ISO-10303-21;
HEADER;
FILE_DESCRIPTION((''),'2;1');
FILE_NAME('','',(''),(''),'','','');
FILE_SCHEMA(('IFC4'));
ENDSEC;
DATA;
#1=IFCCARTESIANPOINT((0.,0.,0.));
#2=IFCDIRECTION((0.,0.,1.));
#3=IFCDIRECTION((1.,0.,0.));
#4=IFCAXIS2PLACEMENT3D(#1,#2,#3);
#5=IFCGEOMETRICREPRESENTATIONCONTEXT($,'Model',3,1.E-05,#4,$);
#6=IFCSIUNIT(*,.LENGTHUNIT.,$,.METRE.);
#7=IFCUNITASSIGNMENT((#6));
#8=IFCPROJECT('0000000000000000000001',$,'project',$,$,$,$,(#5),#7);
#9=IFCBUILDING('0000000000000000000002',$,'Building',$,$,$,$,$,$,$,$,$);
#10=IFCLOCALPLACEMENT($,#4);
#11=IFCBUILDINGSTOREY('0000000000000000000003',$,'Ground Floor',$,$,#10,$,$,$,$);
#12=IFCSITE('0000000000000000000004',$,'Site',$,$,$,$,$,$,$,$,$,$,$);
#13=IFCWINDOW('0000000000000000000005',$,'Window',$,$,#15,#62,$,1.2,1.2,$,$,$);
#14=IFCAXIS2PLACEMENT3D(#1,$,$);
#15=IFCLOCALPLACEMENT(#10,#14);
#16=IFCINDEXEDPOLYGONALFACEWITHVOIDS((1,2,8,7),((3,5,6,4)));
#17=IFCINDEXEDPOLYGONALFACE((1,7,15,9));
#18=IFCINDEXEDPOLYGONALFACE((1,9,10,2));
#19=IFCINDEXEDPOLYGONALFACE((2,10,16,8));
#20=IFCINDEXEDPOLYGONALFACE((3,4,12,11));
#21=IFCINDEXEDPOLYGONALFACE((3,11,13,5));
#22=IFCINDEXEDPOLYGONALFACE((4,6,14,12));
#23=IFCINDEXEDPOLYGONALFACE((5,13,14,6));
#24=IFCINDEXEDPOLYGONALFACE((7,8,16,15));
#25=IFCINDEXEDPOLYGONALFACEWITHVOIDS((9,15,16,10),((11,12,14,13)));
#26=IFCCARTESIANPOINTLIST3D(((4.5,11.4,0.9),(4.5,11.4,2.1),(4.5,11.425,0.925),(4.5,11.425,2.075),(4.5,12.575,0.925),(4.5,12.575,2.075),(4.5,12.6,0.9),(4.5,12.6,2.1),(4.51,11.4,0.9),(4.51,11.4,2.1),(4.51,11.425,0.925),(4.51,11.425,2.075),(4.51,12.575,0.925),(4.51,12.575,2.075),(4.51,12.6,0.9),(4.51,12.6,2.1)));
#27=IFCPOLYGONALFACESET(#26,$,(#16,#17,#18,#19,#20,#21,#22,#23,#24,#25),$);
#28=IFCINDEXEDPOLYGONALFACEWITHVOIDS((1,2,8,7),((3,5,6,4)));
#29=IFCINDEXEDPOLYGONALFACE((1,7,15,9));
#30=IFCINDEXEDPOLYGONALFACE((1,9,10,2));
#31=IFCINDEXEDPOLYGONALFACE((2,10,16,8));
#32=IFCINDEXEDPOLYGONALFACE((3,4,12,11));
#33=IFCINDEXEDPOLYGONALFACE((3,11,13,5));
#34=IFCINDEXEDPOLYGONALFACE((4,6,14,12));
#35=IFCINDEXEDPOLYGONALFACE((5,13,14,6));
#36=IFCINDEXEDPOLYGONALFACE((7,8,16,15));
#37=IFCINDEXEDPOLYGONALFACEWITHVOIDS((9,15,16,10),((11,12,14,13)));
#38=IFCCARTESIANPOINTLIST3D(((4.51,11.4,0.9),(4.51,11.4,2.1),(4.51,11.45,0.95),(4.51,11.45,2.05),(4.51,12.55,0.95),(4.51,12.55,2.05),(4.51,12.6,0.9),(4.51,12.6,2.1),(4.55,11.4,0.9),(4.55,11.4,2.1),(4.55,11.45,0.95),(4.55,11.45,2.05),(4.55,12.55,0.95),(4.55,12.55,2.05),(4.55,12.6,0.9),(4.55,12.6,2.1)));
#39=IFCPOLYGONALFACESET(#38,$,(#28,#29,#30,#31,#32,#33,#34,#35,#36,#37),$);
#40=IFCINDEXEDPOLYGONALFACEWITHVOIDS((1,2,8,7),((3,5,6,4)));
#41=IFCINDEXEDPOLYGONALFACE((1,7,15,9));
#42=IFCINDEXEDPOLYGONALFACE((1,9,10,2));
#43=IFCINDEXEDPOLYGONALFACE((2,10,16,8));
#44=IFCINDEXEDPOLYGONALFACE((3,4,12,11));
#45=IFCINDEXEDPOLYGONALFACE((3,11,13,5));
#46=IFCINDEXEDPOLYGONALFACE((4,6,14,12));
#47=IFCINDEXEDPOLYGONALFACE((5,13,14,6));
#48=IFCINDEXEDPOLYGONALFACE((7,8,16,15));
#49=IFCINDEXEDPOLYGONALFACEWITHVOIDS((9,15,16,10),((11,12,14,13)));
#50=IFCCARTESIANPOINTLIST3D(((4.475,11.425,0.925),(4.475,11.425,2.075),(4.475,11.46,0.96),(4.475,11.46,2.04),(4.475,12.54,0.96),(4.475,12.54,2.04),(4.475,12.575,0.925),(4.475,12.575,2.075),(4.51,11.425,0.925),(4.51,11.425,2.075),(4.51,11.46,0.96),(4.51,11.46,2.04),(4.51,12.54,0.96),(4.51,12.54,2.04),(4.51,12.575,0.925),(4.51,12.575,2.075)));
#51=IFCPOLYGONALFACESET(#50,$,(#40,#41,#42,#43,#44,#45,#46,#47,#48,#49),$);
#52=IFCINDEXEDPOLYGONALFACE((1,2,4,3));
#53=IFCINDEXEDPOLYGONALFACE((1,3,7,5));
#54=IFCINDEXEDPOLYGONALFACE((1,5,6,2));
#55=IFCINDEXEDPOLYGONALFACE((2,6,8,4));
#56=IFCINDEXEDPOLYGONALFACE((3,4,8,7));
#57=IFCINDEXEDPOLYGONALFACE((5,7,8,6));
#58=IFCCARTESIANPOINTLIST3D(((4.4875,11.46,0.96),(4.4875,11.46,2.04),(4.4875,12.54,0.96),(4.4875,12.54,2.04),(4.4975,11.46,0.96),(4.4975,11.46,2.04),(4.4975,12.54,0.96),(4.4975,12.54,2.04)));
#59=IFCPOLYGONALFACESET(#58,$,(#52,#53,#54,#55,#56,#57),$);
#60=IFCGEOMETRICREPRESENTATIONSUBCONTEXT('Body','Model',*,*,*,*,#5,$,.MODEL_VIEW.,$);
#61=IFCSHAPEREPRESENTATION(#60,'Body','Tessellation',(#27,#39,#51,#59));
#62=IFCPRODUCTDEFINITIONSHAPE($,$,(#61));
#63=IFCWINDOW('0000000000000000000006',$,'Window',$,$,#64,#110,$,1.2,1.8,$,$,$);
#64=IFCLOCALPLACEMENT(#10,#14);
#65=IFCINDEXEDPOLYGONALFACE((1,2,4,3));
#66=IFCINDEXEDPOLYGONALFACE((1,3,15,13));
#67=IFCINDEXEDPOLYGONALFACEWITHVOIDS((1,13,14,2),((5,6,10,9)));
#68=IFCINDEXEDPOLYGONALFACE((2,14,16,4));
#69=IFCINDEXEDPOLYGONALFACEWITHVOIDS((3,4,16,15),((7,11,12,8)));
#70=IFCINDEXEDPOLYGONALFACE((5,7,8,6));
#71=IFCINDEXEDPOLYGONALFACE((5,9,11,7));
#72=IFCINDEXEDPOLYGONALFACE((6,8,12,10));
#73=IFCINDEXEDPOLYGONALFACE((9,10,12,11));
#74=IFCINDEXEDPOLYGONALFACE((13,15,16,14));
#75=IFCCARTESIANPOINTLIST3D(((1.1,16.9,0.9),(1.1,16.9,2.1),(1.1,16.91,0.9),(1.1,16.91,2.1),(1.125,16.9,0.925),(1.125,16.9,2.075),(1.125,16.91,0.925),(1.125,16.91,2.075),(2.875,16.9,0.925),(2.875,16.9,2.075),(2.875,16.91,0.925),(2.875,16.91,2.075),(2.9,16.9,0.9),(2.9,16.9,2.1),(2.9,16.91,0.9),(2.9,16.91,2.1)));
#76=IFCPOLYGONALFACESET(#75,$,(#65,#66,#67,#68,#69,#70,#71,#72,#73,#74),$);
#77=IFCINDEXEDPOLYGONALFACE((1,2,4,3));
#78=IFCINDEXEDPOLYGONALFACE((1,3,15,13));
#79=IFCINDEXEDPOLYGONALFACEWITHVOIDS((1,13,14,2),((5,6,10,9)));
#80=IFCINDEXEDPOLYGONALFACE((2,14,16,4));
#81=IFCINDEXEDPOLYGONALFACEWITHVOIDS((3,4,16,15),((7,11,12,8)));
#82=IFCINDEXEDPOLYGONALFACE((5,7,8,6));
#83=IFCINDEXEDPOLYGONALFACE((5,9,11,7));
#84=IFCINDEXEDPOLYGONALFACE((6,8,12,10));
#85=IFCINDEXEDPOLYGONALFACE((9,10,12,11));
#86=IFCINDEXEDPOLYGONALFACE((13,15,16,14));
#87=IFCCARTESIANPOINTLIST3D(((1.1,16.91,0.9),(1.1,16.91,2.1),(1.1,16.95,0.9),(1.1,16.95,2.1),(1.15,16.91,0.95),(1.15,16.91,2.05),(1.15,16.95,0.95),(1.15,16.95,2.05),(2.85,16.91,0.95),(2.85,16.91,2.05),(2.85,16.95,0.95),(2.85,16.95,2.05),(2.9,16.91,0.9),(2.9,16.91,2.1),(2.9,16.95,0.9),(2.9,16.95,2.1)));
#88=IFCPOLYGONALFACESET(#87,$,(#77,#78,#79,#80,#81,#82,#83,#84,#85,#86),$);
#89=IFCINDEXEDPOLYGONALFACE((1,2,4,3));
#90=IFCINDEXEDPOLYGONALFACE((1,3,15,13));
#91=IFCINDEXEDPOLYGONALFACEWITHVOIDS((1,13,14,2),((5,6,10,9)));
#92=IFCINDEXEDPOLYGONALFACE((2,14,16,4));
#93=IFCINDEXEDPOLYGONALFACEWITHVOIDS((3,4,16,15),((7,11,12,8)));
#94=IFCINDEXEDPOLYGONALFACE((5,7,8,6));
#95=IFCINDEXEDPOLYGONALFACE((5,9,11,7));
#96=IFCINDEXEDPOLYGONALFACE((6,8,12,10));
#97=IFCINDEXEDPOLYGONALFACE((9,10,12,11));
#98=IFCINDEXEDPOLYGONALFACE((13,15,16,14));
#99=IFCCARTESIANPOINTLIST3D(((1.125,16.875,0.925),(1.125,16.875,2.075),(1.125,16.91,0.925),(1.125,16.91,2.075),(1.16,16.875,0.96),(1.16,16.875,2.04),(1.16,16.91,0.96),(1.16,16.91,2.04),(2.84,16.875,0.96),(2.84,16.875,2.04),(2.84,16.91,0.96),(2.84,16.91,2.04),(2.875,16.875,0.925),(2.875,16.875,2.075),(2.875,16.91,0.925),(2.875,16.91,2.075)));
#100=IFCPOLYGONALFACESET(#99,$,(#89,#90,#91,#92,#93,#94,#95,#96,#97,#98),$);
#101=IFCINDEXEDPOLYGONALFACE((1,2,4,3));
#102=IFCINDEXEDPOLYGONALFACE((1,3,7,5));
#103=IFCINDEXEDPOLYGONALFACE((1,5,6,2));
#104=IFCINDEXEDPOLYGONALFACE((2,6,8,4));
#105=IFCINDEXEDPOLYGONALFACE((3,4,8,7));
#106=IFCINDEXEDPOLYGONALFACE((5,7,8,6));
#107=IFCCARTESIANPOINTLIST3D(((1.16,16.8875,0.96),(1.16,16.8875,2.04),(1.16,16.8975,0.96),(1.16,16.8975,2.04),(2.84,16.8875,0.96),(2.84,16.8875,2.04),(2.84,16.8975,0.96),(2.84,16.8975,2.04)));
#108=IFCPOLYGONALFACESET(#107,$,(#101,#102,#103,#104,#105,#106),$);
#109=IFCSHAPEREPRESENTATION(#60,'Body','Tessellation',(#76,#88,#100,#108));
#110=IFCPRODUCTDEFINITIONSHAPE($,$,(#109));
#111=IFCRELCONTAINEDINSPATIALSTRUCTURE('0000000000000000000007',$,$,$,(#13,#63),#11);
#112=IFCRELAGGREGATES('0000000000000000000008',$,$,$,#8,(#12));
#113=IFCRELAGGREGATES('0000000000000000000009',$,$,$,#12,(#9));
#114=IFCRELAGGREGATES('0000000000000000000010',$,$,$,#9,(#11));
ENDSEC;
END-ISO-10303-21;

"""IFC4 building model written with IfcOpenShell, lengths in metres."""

from ifc_helpers import new_model, si_unit, frame, origin_with_axes, place, context, subcontext, project, spatial, line, indexed_curve, outline, extrude, element, save


model = new_model("IFC4")

# Units and contexts
model_context = context("Model", 3, precision=1e-05, world=origin_with_axes())
body_context = subcontext(model_context, "Body", "Model", "MODEL_VIEW")
ifc_project = project(units=[si_unit("LENGTHUNIT", "METRE")], contexts=[model_context])

# Site, building, storey
site = spatial("IfcSite", under=ifc_project, Name="Site")
building = spatial("IfcBuilding", under=site, Name="Building")
storey_placement = place(None, origin_with_axes())
storey = spatial("IfcBuildingStorey", under=building, at=storey_placement, Name="Ground Floor")

# Windows
window_1_placement = place(storey_placement, frame((4.6, 11.4, 0.9), z_axis=(0.0, 0.0, 1.0), x_axis=(0.0, 1.0, 0.0)))
element("IfcWindow", 1, at=window_1_placement, inside=storey, Name="Window", OverallHeight=1.2, OverallWidth=1.2, context=body_context, shape_type="SweptSolid", body=[
    extrude(outline(indexed_curve([(0.0, 0.0), (1.2, 0.0), (1.2, 1.2), (0.0, 1.2)], segments=[line(1, 2, 3, 4, 1)]), holes=[indexed_curve([(0.025, 0.025), (1.175, 0.025), (1.175, 1.175), (0.025, 1.175)], segments=[line(1, 2, 3, 4, 1)])]), frame((0.0, 0.09, 0.0), z_axis=(0.0, -1.0, 0.0), x_axis=(1.0, 0.0, 0.0)), (0.0, 0.0, -1.0), 0.01),
    extrude(outline(indexed_curve([(0.0, 0.0), (1.2, 0.0), (1.2, 1.2), (0.0, 1.2)], segments=[line(1, 2, 3, 4, 1)]), holes=[indexed_curve([(0.05, 0.05), (1.15, 0.05), (1.15, 1.15), (0.05, 1.15)], segments=[line(1, 2, 3, 4, 1)])]), frame((0.0, 0.05, 0.0), z_axis=(0.0, -1.0, 0.0), x_axis=(1.0, 0.0, 0.0)), (0.0, 0.0, -1.0), 0.04),
    extrude(outline(indexed_curve([(0.0, 0.0), (1.15, 0.0), (1.15, 1.15), (0.0, 1.15)], segments=[line(1, 2, 3, 4, 1)]), holes=[indexed_curve([(0.035, 0.035), (1.115, 0.035), (1.115, 1.115), (0.035, 1.115)], segments=[line(1, 2, 3, 4, 1)])]), frame((0.025, 0.09, 0.025), z_axis=(0.0, -1.0, 0.0), x_axis=(1.0, 0.0, 0.0)), (0.0, 0.0, -1.0), 0.035),
    extrude(outline(indexed_curve([(0.035, 0.035), (1.115, 0.035), (1.115, 1.115), (0.035, 1.115)], segments=[line(1, 2, 3, 4, 1)])), frame((0.025, 0.1025, 0.025), z_axis=(0.0, -1.0, 0.0), x_axis=(1.0, 0.0, 0.0)), (0.0, 0.0, -1.0), 0.01),
])
window_2_placement = place(storey_placement, frame((2.9, 17.0, 0.9), z_axis=(0.0, 0.0, 1.0), x_axis=(-1.0, 0.0, 0.0)))
element("IfcWindow", 2, at=window_2_placement, inside=storey, Name="Window", OverallHeight=1.2, OverallWidth=1.8, context=body_context, shape_type="SweptSolid", body=[
    extrude(outline(indexed_curve([(0.0, 0.0), (1.8, 0.0), (1.8, 1.2), (0.0, 1.2)], segments=[line(1, 2, 3, 4, 1)]), holes=[indexed_curve([(0.025, 0.025), (1.775, 0.025), (1.775, 1.175), (0.025, 1.175)], segments=[line(1, 2, 3, 4, 1)])]), frame((0.0, 0.09, 0.0), z_axis=(0.0, -1.0, 0.0), x_axis=(1.0, 0.0, 0.0)), (0.0, 0.0, -1.0), 0.01),
    extrude(outline(indexed_curve([(0.0, 0.0), (1.8, 0.0), (1.8, 1.2), (0.0, 1.2)], segments=[line(1, 2, 3, 4, 1)]), holes=[indexed_curve([(0.05, 0.05), (1.75, 0.05), (1.75, 1.15), (0.05, 1.15)], segments=[line(1, 2, 3, 4, 1)])]), frame((0.0, 0.05, 0.0), z_axis=(0.0, -1.0, 0.0), x_axis=(1.0, 0.0, 0.0)), (0.0, 0.0, -1.0), 0.04),
    extrude(outline(indexed_curve([(0.0, 0.0), (1.75, 0.0), (1.75, 1.15), (0.0, 1.15)], segments=[line(1, 2, 3, 4, 1)]), holes=[indexed_curve([(0.035, 0.035), (1.715, 0.035), (1.715, 1.115), (0.035, 1.115)], segments=[line(1, 2, 3, 4, 1)])]), frame((0.025, 0.09, 0.025), z_axis=(0.0, -1.0, 0.0), x_axis=(1.0, 0.0, 0.0)), (0.0, 0.0, -1.0), 0.035),
    extrude(outline(indexed_curve([(0.035, 0.035), (1.715, 0.035), (1.715, 1.115), (0.035, 1.115)], segments=[line(1, 2, 3, 4, 1)])), frame((0.025, 0.1025, 0.025), z_axis=(0.0, -1.0, 0.0), x_axis=(1.0, 0.0, 0.0)), (0.0, 0.0, -1.0), 0.01),
])

save(model, "model.ifc")
